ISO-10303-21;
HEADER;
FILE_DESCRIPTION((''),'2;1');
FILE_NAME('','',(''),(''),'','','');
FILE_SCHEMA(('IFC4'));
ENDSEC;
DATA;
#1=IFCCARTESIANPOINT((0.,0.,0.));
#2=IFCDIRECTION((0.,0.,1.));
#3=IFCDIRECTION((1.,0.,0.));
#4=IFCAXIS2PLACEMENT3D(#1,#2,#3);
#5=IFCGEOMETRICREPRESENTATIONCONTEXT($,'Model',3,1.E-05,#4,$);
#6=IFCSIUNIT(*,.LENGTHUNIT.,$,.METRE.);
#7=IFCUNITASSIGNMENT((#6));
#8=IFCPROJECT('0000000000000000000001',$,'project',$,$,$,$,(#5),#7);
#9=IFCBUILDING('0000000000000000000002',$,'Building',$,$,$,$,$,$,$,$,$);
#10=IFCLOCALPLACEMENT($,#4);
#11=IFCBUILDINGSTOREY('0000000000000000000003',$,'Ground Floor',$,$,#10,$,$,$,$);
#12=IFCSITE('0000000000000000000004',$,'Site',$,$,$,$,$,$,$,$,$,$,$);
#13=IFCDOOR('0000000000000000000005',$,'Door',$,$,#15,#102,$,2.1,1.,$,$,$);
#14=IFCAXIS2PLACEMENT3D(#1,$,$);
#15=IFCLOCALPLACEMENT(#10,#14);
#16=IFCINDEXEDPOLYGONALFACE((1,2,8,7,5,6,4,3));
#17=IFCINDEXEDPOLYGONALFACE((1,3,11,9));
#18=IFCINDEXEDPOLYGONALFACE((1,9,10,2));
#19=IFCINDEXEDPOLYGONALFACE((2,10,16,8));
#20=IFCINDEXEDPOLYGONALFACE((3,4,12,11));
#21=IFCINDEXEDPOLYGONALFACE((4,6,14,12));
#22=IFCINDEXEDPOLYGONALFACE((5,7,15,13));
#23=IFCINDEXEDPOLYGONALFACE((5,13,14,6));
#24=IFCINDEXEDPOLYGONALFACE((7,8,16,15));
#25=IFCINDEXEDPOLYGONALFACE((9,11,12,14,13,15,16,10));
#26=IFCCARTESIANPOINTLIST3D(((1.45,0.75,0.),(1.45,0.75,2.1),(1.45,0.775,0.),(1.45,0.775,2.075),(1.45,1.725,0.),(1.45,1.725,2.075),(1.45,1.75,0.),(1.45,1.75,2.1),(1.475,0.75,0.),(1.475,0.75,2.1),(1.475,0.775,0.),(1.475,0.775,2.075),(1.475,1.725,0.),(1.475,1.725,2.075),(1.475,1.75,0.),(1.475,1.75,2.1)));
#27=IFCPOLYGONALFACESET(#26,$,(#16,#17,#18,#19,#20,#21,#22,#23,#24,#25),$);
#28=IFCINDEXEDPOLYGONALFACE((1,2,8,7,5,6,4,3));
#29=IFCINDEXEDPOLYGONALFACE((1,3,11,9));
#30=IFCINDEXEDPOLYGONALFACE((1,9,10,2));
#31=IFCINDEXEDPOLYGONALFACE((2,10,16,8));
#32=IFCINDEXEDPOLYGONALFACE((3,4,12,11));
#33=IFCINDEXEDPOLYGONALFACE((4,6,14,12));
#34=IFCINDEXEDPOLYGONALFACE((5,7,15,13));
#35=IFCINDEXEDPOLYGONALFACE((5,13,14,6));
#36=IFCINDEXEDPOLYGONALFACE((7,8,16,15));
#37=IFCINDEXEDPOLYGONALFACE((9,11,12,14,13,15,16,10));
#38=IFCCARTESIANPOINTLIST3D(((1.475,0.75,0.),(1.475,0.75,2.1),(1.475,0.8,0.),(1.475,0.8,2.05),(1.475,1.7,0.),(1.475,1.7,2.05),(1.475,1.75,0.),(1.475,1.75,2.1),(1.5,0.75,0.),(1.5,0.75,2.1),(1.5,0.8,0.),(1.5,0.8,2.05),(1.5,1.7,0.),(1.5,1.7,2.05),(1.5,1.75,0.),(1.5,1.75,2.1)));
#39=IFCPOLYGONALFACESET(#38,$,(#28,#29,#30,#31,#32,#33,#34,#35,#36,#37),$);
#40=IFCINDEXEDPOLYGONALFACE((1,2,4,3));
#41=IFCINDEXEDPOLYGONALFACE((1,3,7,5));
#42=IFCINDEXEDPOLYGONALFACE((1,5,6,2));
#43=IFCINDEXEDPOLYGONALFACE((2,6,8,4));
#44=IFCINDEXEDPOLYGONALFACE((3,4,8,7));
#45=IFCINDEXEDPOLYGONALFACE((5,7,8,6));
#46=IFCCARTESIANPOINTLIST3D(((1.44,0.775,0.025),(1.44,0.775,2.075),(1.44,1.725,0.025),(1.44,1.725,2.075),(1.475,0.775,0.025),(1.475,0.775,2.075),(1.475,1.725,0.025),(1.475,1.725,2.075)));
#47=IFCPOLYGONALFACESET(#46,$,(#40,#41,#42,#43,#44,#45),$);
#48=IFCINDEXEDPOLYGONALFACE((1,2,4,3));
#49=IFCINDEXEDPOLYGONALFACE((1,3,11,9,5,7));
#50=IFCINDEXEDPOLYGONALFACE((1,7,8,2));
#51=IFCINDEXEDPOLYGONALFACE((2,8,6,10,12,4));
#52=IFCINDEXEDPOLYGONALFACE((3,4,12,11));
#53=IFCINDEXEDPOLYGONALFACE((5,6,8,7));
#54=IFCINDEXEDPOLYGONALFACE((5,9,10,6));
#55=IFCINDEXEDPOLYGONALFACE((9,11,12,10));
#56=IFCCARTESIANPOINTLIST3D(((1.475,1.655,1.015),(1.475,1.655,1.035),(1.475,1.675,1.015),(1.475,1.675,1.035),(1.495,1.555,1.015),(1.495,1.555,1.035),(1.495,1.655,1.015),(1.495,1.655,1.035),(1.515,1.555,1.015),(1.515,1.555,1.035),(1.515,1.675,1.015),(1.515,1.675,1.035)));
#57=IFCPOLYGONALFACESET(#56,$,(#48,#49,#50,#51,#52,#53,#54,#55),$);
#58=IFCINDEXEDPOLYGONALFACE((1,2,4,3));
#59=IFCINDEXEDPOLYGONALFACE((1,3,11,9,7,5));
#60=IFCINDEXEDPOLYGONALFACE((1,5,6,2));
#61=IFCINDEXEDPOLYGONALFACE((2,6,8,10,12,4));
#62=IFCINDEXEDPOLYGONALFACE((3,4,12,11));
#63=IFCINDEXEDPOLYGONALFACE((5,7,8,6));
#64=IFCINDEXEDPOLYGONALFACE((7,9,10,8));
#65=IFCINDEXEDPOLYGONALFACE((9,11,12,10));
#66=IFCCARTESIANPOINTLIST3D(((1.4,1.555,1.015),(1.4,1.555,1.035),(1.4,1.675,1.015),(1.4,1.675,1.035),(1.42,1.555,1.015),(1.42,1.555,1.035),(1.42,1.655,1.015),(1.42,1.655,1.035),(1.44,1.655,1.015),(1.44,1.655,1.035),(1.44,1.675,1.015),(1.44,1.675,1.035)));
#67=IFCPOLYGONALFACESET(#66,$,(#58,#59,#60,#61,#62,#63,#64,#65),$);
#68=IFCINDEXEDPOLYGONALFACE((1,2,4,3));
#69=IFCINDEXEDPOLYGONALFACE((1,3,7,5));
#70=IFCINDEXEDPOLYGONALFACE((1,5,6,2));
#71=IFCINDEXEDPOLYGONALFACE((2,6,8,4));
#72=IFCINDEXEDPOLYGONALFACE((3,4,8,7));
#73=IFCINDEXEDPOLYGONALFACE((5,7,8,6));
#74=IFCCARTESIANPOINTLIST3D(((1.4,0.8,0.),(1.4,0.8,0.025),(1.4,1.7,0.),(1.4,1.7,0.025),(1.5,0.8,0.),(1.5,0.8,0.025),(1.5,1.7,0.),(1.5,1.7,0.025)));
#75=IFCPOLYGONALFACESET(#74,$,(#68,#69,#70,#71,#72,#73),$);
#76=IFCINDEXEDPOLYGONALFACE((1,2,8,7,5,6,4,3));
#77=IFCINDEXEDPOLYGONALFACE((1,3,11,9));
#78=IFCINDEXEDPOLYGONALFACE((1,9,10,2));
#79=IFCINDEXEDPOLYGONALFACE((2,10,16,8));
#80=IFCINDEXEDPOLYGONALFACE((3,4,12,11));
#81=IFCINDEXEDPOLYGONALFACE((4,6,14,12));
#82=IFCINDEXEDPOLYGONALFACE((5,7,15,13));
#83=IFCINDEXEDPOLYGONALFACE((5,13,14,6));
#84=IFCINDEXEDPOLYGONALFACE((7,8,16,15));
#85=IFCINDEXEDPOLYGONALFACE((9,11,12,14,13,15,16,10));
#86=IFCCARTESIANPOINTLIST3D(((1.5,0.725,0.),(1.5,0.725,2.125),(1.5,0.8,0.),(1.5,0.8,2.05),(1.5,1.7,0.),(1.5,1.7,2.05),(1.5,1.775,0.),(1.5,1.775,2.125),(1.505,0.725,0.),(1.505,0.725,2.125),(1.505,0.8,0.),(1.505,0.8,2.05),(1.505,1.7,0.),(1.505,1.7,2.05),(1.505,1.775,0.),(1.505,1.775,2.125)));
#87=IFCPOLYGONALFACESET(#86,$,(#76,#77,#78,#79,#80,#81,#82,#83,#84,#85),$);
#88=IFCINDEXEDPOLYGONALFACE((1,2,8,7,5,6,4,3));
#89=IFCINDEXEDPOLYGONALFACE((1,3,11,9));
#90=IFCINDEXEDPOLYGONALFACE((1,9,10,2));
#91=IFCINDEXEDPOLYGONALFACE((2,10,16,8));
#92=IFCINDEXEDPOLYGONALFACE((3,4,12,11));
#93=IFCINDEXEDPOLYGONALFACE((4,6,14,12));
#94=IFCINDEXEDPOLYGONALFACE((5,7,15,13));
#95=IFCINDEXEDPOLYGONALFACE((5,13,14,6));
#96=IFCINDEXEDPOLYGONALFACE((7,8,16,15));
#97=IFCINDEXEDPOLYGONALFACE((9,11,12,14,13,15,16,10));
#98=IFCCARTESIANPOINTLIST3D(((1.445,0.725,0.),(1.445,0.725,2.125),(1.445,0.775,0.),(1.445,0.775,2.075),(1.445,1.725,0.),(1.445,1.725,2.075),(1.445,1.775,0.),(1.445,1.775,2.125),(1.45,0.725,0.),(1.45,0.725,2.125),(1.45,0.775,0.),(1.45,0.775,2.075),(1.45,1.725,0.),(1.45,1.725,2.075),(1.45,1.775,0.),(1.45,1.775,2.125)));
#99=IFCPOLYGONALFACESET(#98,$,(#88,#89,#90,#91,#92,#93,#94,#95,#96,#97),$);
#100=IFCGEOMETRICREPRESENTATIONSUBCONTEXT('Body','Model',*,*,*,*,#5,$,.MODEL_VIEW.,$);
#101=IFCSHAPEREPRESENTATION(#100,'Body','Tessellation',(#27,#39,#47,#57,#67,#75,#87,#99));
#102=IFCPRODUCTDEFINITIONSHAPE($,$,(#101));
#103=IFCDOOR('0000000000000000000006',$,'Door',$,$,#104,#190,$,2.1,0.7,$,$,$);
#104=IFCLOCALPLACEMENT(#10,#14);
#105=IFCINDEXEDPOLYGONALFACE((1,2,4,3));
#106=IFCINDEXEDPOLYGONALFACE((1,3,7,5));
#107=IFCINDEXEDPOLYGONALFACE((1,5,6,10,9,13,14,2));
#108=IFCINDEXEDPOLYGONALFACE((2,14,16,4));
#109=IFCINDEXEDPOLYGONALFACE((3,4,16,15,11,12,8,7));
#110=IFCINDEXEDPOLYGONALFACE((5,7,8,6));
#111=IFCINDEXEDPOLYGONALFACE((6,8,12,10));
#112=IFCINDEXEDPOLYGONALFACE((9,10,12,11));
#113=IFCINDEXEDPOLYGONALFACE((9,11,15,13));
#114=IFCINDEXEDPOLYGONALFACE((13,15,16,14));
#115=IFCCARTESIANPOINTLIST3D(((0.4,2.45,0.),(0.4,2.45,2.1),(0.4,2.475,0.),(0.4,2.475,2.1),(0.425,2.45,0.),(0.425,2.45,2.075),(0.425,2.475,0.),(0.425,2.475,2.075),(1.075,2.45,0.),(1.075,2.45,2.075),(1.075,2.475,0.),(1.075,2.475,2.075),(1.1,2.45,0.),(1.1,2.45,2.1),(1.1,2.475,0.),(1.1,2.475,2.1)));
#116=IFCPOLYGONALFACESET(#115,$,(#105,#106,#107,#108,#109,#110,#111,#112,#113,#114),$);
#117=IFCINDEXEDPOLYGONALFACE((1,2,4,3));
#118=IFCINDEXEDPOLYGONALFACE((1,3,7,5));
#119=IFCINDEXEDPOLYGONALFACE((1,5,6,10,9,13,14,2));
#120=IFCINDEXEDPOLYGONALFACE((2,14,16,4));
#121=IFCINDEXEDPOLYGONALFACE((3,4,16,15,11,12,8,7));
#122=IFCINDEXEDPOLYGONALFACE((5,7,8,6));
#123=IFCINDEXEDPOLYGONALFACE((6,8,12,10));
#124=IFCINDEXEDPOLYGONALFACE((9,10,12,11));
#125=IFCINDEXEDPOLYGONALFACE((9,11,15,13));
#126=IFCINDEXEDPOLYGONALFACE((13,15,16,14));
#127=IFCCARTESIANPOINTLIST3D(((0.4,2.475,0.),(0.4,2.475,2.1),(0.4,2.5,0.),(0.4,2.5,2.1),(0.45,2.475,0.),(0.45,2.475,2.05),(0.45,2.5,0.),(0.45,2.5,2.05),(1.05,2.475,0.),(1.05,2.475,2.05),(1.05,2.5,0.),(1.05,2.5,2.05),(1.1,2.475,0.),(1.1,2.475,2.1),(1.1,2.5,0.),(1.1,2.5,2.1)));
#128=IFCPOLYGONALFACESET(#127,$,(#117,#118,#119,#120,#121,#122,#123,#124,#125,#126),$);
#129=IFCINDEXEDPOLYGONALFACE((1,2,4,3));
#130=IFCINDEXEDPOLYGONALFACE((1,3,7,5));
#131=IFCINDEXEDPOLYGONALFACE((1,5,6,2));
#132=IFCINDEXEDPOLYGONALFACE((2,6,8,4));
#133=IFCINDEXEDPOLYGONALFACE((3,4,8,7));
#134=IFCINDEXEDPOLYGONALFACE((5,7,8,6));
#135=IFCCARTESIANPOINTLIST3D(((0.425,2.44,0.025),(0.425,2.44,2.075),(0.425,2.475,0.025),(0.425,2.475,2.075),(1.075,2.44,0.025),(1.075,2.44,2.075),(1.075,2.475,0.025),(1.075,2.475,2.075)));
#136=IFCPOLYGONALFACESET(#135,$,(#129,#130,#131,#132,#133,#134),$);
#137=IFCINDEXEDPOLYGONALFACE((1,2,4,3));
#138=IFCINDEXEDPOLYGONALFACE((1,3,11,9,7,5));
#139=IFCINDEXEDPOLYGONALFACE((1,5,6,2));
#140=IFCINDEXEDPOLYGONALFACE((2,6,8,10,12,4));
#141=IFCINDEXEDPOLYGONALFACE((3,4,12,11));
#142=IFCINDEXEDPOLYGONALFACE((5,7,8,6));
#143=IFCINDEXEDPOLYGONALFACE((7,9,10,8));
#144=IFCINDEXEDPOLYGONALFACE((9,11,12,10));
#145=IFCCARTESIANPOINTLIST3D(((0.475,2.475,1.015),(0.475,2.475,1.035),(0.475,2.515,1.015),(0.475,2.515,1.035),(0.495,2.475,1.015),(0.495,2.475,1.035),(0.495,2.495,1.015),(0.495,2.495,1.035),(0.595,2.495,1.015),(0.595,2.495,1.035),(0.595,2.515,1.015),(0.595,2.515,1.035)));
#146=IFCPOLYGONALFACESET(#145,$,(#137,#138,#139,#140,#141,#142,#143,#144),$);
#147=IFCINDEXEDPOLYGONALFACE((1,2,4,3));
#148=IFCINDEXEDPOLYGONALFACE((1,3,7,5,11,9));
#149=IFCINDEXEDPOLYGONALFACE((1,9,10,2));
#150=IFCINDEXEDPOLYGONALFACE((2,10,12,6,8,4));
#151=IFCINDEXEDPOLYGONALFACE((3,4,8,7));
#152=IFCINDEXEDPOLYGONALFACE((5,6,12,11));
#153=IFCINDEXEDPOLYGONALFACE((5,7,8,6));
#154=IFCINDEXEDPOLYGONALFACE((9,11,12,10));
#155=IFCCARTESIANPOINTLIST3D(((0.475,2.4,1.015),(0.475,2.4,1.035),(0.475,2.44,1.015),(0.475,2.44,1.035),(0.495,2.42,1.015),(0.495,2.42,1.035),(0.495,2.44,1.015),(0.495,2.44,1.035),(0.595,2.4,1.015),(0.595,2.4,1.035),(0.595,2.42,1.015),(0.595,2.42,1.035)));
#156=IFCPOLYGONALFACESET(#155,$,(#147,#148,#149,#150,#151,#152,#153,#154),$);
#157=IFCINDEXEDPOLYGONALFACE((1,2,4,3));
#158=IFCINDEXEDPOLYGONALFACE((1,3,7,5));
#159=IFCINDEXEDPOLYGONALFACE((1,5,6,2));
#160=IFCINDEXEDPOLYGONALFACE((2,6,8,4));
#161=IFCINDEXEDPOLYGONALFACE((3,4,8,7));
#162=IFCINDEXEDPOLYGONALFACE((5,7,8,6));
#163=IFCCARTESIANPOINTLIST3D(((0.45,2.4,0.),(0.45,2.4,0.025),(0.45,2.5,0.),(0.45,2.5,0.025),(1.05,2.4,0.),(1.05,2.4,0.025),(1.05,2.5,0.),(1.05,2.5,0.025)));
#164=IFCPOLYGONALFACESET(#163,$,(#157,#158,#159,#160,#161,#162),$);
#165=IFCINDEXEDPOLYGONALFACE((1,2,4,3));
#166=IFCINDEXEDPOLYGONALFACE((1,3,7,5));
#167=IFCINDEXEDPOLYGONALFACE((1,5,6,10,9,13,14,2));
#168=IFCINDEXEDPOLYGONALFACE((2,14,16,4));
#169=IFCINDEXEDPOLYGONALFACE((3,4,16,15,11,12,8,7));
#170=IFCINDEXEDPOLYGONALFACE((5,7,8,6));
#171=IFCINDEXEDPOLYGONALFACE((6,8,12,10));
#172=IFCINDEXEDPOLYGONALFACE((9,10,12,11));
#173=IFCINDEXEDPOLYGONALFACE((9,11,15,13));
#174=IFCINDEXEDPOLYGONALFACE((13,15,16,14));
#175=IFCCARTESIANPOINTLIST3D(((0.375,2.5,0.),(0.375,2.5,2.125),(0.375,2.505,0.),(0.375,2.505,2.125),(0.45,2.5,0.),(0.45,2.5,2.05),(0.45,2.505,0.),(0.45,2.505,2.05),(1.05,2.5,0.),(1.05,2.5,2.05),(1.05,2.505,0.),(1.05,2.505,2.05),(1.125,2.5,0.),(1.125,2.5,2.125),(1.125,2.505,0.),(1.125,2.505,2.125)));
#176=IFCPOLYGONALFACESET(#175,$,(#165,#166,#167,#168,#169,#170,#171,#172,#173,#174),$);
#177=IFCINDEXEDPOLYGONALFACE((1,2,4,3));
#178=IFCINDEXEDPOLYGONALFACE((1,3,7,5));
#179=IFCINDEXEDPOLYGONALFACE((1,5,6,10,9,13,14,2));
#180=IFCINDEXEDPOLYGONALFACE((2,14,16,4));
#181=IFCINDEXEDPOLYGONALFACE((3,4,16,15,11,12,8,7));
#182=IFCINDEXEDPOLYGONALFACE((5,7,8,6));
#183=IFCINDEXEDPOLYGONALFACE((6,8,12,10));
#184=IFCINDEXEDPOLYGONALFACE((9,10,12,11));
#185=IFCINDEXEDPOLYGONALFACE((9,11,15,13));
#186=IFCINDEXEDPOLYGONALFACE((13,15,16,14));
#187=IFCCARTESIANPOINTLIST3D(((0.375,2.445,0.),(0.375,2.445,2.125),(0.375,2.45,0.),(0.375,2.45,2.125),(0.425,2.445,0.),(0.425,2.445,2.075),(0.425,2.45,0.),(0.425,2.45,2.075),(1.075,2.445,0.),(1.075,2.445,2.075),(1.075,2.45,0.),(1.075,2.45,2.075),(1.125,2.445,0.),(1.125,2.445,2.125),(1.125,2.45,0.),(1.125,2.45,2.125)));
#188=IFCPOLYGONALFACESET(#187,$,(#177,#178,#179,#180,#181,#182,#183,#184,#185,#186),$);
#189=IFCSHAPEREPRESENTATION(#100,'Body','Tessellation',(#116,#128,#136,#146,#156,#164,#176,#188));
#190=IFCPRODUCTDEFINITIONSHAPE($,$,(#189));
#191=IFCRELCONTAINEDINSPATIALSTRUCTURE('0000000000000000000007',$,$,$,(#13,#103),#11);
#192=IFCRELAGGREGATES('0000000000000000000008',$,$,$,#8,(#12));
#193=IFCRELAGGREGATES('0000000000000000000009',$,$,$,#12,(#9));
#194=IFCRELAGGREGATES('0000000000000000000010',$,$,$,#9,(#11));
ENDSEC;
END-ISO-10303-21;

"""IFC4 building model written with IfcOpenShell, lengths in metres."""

from ifc_helpers import new_model, si_unit, frame, origin_with_axes, place, context, subcontext, project, spatial, line, indexed_curve, outline, extrude, element, save


model = new_model("IFC4")

# Units and contexts
model_context = context("Model", 3, precision=1e-05, world=origin_with_axes())
body_context = subcontext(model_context, "Body", "Model", "MODEL_VIEW")
ifc_project = project(units=[si_unit("LENGTHUNIT", "METRE")], contexts=[model_context])

# Site, building, storey
site = spatial("IfcSite", under=ifc_project, Name="Site")
building = spatial("IfcBuilding", under=site, Name="Building")
storey_placement = place(None, origin_with_axes())
storey = spatial("IfcBuildingStorey", under=building, at=storey_placement, Name="Ground Floor")

# Doors
door_1_placement = place(storey_placement, frame((1.5, 0.75, 0.0), z_axis=(0.0, 0.0, 1.0), x_axis=(0.0, 1.0, 0.0)))
element("IfcDoor", 1, at=door_1_placement, inside=storey, Name="Door", OverallHeight=2.1, OverallWidth=1.0, context=body_context, shape_type="SweptSolid", body=[
    extrude(outline(indexed_curve([(0.0, 0.0), (0.0, 2.1), (1.0, 2.1), (1.0, 0.0), (0.975, 0.0), (0.975, 2.075), (0.025, 2.075), (0.025, 0.0)], segments=[line(1, 2, 3, 4, 5, 6, 7, 8, 1)])), frame((0.0, 0.025, 0.0), z_axis=(0.0, -1.0, 0.0), x_axis=(1.0, 0.0, 0.0)), (0.0, 0.0, -1.0), 0.025),
    extrude(outline(indexed_curve([(0.0, 0.0), (0.0, 2.1), (1.0, 2.1), (1.0, 0.0), (0.95, 0.0), (0.95, 2.05), (0.05, 2.05), (0.05, 0.0)], segments=[line(1, 2, 3, 4, 5, 6, 7, 8, 1)])), frame((0.0, 0.0, 0.0), z_axis=(0.0, -1.0, 0.0), x_axis=(1.0, 0.0, 0.0)), (0.0, 0.0, -1.0), 0.025),
    extrude(outline(indexed_curve([(0.0, 0.0), (0.95, 0.0), (0.95, 0.035), (0.0, 0.035)], segments=[line(1, 2, 3, 4, 1)])), frame((0.025, 0.025, 0.025), z_axis=(0.0, 0.0, 1.0), x_axis=(1.0, 0.0, 0.0)), (0.0, 0.0, 1.0), 2.05),
    extrude(outline(indexed_curve([(0.0, 0.0), (0.0, -0.04), (-0.12, -0.04), (-0.12, -0.02), (-0.02, -0.02), (-0.02, 0.0)], segments=[line(1, 2, 3, 4, 5, 6, 1)])), frame((0.925, 0.025, 1.015), z_axis=(0.0, 0.0, 1.0), x_axis=(1.0, 0.0, 0.0)), (0.0, 0.0, 1.0), 0.02),
    extrude(outline(indexed_curve([(0.0, 0.0), (0.0, 0.04), (-0.12, 0.04), (-0.12, 0.02), (-0.02, 0.02), (-0.02, 0.0)], segments=[line(1, 2, 3, 4, 5, 6, 1)])), frame((0.925, 0.06, 1.015), z_axis=(0.0, 0.0, 1.0), x_axis=(1.0, 0.0, 0.0)), (0.0, 0.0, 1.0), 0.02),
    extrude(outline(indexed_curve([(0.0, 0.0), (0.9, 0.0), (0.9, 0.1), (0.0, 0.1)], segments=[line(1, 2, 3, 4, 1)])), frame((0.05, 0.0, 0.0), z_axis=(0.0, 0.0, 1.0), x_axis=(1.0, 0.0, 0.0)), (0.0, 0.0, 1.0), 0.025),
    extrude(outline(indexed_curve([(0.0, 0.0), (0.0, 2.125), (1.05, 2.125), (1.05, 0.0), (0.975, 0.0), (0.975, 2.05), (0.075, 2.05), (0.075, 0.0)], segments=[line(1, 2, 3, 4, 5, 6, 7, 8, 1)])), frame((-0.025, -0.005, 0.0), z_axis=(0.0, -1.0, 0.0), x_axis=(1.0, 0.0, 0.0)), (0.0, 0.0, -1.0), 0.005),
    extrude(outline(indexed_curve([(0.0, 0.0), (0.0, 2.125), (1.05, 2.125), (1.05, 0.0), (1.0, 0.0), (1.0, 2.075), (0.05, 2.075), (0.05, 0.0)], segments=[line(1, 2, 3, 4, 5, 6, 7, 8, 1)])), frame((-0.025, 0.05, 0.0), z_axis=(0.0, -1.0, 0.0), x_axis=(1.0, 0.0, 0.0)), (0.0, 0.0, -1.0), 0.005),
])
door_2_placement = place(storey_placement, frame((1.1, 2.5, 0.0), z_axis=(0.0, 0.0, 1.0), x_axis=(-1.0, 0.0, 0.0)))
element("IfcDoor", 2, at=door_2_placement, inside=storey, Name="Door", OverallHeight=2.1, OverallWidth=0.7, context=body_context, shape_type="SweptSolid", body=[
    extrude(outline(indexed_curve([(0.0, 0.0), (0.0, 2.1), (0.7, 2.1), (0.7, 0.0), (0.675, 0.0), (0.675, 2.075), (0.025, 2.075), (0.025, 0.0)], segments=[line(1, 2, 3, 4, 5, 6, 7, 8, 1)])), frame((0.0, 0.025, 0.0), z_axis=(0.0, -1.0, 0.0), x_axis=(1.0, 0.0, 0.0)), (0.0, 0.0, -1.0), 0.025),
    extrude(outline(indexed_curve([(0.0, 0.0), (0.0, 2.1), (0.7, 2.1), (0.7, 0.0), (0.65, 0.0), (0.65, 2.05), (0.05, 2.05), (0.05, 0.0)], segments=[line(1, 2, 3, 4, 5, 6, 7, 8, 1)])), frame((0.0, 0.0, 0.0), z_axis=(0.0, -1.0, 0.0), x_axis=(1.0, 0.0, 0.0)), (0.0, 0.0, -1.0), 0.025),
    extrude(outline(indexed_curve([(0.0, 0.0), (0.65, 0.0), (0.65, 0.035), (0.0, 0.035)], segments=[line(1, 2, 3, 4, 1)])), frame((0.025, 0.025, 0.025), z_axis=(0.0, 0.0, 1.0), x_axis=(1.0, 0.0, 0.0)), (0.0, 0.0, 1.0), 2.05),
    extrude(outline(indexed_curve([(0.0, 0.0), (0.0, -0.04), (-0.12, -0.04), (-0.12, -0.02), (-0.02, -0.02), (-0.02, 0.0)], segments=[line(1, 2, 3, 4, 5, 6, 1)])), frame((0.625, 0.025, 1.015), z_axis=(0.0, 0.0, 1.0), x_axis=(1.0, 0.0, 0.0)), (0.0, 0.0, 1.0), 0.02),
    extrude(outline(indexed_curve([(0.0, 0.0), (0.0, 0.04), (-0.12, 0.04), (-0.12, 0.02), (-0.02, 0.02), (-0.02, 0.0)], segments=[line(1, 2, 3, 4, 5, 6, 1)])), frame((0.625, 0.06, 1.015), z_axis=(0.0, 0.0, 1.0), x_axis=(1.0, 0.0, 0.0)), (0.0, 0.0, 1.0), 0.02),
    extrude(outline(indexed_curve([(0.0, 0.0), (0.6, 0.0), (0.6, 0.1), (0.0, 0.1)], segments=[line(1, 2, 3, 4, 1)])), frame((0.05, 0.0, 0.0), z_axis=(0.0, 0.0, 1.0), x_axis=(1.0, 0.0, 0.0)), (0.0, 0.0, 1.0), 0.025),
    extrude(outline(indexed_curve([(0.0, 0.0), (0.0, 2.125), (0.75, 2.125), (0.75, 0.0), (0.675, 0.0), (0.675, 2.05), (0.075, 2.05), (0.075, 0.0)], segments=[line(1, 2, 3, 4, 5, 6, 7, 8, 1)])), frame((-0.025, -0.005, 0.0), z_axis=(0.0, -1.0, 0.0), x_axis=(1.0, 0.0, 0.0)), (0.0, 0.0, -1.0), 0.005),
    extrude(outline(indexed_curve([(0.0, 0.0), (0.0, 2.125), (0.75, 2.125), (0.75, 0.0), (0.7, 0.0), (0.7, 2.075), (0.05, 2.075), (0.05, 0.0)], segments=[line(1, 2, 3, 4, 5, 6, 7, 8, 1)])), frame((-0.025, 0.05, 0.0), z_axis=(0.0, -1.0, 0.0), x_axis=(1.0, 0.0, 0.0)), (0.0, 0.0, -1.0), 0.005),
])

save(model, "model.ifc")
